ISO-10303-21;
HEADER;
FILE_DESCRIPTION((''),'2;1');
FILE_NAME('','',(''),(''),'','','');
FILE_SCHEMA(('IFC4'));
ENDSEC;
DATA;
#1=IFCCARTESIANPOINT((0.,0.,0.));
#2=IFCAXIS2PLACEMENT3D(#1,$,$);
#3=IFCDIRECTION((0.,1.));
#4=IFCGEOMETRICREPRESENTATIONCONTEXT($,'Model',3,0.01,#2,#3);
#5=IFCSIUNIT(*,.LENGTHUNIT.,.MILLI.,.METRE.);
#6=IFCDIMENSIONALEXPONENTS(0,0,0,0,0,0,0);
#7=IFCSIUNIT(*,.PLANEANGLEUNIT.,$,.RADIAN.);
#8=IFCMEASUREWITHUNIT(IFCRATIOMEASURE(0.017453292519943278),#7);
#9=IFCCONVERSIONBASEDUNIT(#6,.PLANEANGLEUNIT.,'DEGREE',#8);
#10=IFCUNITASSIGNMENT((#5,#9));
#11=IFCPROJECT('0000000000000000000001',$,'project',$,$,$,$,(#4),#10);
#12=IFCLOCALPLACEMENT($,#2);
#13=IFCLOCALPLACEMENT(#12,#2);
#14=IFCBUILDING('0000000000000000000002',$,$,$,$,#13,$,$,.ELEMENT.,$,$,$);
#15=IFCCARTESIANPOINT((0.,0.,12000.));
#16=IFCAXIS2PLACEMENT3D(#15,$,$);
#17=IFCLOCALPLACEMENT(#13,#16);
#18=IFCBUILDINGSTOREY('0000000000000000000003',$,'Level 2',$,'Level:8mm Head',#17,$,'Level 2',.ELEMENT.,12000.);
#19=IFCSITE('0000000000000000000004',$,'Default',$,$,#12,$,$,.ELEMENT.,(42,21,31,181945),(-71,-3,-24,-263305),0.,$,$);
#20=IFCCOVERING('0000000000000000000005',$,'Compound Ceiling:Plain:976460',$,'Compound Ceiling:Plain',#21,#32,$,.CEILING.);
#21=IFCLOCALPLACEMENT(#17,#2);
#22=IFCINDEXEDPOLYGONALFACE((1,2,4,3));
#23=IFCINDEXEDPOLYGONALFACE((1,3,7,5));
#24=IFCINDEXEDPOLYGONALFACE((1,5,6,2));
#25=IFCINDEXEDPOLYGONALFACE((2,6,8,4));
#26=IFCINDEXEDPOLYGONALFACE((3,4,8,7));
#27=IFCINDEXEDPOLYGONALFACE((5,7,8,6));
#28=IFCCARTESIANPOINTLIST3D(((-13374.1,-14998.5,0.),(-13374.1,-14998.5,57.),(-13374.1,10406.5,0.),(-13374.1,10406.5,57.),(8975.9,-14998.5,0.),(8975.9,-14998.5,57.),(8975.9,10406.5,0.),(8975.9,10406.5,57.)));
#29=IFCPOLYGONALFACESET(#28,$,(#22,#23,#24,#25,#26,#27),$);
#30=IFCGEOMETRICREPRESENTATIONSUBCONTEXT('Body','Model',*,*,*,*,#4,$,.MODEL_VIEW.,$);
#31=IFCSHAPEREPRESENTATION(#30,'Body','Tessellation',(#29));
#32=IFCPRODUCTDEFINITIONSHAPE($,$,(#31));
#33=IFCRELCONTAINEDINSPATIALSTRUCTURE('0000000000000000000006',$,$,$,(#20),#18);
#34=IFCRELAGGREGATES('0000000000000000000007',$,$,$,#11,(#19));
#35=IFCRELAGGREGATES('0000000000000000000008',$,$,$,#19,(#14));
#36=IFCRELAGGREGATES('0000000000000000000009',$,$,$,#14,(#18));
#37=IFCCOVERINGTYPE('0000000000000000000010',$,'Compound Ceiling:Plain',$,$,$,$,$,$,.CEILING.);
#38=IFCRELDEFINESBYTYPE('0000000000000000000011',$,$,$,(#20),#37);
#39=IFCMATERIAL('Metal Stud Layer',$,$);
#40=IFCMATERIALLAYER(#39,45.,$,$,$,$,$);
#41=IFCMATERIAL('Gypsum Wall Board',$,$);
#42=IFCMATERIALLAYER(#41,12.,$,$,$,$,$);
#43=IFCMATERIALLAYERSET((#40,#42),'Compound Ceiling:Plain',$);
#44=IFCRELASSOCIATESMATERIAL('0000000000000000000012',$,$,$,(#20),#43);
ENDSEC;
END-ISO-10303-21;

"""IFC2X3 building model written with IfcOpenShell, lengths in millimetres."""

from ifc_helpers import new_model, entity, si_unit, converted_unit, direction, frame, frame_2d, origin, place, context, subcontext, project, spatial, rectangle, extrude, material, layer, layer_set, layer_usage, type_object, element, save


model = new_model("IFC2X3")

# Units and contexts
model_context = context("Model", 3, precision=0.01, world=origin(), true_north=direction((0.0, 1.0)))
body_context = subcontext(model_context, "Body", "Model", "MODEL_VIEW")
ifc_project = project(units=[si_unit("LENGTHUNIT", "METRE", prefix="MILLI"), converted_unit("PLANEANGLEUNIT", "DEGREE", entity("IfcRatioMeasure", 0.017453292519943278), si_unit("PLANEANGLEUNIT", "RADIAN"), dimensions=[0, 0, 0, 0, 0, 0, 0])], contexts=[model_context])

# Site, building, storey
site_placement = place(None, origin())
site = spatial("IfcSite", under=ifc_project, at=site_placement, Name="Default", CompositionType="ELEMENT", RefLatitude=(42, 21, 31, 181945), RefLongitude=(-71, -3, -24, -263305), RefElevation=0.0)
building_placement = place(site_placement, origin())
building = spatial("IfcBuilding", under=site, at=building_placement, CompositionType="ELEMENT")
storey_placement = place(building_placement, frame((0.0, 0.0, 12000.0)))
storey = spatial("IfcBuildingStorey", under=building, at=storey_placement, Name="Level 2", ObjectType="Level:8mm Head", LongName="Level 2", CompositionType="ELEMENT", Elevation=12000.0)

# Covering
ifc_material_1 = material(Name="Metal Stud Layer")
ifc_layer_1 = layer(ifc_material_1, 45.0)
ifc_material_2 = material(Name="Gypsum Wall Board")
ifc_layer_2 = layer(ifc_material_2, 12.0)
ifc_layer_set = layer_set([ifc_layer_1, ifc_layer_2], Name="Compound Ceiling:Plain")
ifc_layer_usage = layer_usage(ifc_layer_set, "AXIS3", "POSITIVE", 0.0)
covering_type = type_object("IfcCoveringType", Name="Compound Ceiling:Plain", PredefinedType="CEILING")
covering_placement = place(storey_placement, frame((-13374.1, -14998.5, 0.0)))
element("IfcCovering", 1, at=covering_placement, inside=storey, type_object=covering_type, material=ifc_layer_usage, Name="Compound Ceiling:Plain:976460", ObjectType="Compound Ceiling:Plain", PredefinedType="CEILING", context=body_context, shape_type="SweptSolid", body=[
    extrude(rectangle(XDim=22350.0, YDim=25405.0, at=frame_2d((0.0, 0.0), x_axis=(1.0, 0.0))), frame((11175.0, 12702.5, 0.0), z_axis=(0.0, 0.0, 1.0), x_axis=(-1.0, 0.0, 0.0)), (0.0, 0.0, 1.0), 57.0),
])

save(model, "model.ifc")
